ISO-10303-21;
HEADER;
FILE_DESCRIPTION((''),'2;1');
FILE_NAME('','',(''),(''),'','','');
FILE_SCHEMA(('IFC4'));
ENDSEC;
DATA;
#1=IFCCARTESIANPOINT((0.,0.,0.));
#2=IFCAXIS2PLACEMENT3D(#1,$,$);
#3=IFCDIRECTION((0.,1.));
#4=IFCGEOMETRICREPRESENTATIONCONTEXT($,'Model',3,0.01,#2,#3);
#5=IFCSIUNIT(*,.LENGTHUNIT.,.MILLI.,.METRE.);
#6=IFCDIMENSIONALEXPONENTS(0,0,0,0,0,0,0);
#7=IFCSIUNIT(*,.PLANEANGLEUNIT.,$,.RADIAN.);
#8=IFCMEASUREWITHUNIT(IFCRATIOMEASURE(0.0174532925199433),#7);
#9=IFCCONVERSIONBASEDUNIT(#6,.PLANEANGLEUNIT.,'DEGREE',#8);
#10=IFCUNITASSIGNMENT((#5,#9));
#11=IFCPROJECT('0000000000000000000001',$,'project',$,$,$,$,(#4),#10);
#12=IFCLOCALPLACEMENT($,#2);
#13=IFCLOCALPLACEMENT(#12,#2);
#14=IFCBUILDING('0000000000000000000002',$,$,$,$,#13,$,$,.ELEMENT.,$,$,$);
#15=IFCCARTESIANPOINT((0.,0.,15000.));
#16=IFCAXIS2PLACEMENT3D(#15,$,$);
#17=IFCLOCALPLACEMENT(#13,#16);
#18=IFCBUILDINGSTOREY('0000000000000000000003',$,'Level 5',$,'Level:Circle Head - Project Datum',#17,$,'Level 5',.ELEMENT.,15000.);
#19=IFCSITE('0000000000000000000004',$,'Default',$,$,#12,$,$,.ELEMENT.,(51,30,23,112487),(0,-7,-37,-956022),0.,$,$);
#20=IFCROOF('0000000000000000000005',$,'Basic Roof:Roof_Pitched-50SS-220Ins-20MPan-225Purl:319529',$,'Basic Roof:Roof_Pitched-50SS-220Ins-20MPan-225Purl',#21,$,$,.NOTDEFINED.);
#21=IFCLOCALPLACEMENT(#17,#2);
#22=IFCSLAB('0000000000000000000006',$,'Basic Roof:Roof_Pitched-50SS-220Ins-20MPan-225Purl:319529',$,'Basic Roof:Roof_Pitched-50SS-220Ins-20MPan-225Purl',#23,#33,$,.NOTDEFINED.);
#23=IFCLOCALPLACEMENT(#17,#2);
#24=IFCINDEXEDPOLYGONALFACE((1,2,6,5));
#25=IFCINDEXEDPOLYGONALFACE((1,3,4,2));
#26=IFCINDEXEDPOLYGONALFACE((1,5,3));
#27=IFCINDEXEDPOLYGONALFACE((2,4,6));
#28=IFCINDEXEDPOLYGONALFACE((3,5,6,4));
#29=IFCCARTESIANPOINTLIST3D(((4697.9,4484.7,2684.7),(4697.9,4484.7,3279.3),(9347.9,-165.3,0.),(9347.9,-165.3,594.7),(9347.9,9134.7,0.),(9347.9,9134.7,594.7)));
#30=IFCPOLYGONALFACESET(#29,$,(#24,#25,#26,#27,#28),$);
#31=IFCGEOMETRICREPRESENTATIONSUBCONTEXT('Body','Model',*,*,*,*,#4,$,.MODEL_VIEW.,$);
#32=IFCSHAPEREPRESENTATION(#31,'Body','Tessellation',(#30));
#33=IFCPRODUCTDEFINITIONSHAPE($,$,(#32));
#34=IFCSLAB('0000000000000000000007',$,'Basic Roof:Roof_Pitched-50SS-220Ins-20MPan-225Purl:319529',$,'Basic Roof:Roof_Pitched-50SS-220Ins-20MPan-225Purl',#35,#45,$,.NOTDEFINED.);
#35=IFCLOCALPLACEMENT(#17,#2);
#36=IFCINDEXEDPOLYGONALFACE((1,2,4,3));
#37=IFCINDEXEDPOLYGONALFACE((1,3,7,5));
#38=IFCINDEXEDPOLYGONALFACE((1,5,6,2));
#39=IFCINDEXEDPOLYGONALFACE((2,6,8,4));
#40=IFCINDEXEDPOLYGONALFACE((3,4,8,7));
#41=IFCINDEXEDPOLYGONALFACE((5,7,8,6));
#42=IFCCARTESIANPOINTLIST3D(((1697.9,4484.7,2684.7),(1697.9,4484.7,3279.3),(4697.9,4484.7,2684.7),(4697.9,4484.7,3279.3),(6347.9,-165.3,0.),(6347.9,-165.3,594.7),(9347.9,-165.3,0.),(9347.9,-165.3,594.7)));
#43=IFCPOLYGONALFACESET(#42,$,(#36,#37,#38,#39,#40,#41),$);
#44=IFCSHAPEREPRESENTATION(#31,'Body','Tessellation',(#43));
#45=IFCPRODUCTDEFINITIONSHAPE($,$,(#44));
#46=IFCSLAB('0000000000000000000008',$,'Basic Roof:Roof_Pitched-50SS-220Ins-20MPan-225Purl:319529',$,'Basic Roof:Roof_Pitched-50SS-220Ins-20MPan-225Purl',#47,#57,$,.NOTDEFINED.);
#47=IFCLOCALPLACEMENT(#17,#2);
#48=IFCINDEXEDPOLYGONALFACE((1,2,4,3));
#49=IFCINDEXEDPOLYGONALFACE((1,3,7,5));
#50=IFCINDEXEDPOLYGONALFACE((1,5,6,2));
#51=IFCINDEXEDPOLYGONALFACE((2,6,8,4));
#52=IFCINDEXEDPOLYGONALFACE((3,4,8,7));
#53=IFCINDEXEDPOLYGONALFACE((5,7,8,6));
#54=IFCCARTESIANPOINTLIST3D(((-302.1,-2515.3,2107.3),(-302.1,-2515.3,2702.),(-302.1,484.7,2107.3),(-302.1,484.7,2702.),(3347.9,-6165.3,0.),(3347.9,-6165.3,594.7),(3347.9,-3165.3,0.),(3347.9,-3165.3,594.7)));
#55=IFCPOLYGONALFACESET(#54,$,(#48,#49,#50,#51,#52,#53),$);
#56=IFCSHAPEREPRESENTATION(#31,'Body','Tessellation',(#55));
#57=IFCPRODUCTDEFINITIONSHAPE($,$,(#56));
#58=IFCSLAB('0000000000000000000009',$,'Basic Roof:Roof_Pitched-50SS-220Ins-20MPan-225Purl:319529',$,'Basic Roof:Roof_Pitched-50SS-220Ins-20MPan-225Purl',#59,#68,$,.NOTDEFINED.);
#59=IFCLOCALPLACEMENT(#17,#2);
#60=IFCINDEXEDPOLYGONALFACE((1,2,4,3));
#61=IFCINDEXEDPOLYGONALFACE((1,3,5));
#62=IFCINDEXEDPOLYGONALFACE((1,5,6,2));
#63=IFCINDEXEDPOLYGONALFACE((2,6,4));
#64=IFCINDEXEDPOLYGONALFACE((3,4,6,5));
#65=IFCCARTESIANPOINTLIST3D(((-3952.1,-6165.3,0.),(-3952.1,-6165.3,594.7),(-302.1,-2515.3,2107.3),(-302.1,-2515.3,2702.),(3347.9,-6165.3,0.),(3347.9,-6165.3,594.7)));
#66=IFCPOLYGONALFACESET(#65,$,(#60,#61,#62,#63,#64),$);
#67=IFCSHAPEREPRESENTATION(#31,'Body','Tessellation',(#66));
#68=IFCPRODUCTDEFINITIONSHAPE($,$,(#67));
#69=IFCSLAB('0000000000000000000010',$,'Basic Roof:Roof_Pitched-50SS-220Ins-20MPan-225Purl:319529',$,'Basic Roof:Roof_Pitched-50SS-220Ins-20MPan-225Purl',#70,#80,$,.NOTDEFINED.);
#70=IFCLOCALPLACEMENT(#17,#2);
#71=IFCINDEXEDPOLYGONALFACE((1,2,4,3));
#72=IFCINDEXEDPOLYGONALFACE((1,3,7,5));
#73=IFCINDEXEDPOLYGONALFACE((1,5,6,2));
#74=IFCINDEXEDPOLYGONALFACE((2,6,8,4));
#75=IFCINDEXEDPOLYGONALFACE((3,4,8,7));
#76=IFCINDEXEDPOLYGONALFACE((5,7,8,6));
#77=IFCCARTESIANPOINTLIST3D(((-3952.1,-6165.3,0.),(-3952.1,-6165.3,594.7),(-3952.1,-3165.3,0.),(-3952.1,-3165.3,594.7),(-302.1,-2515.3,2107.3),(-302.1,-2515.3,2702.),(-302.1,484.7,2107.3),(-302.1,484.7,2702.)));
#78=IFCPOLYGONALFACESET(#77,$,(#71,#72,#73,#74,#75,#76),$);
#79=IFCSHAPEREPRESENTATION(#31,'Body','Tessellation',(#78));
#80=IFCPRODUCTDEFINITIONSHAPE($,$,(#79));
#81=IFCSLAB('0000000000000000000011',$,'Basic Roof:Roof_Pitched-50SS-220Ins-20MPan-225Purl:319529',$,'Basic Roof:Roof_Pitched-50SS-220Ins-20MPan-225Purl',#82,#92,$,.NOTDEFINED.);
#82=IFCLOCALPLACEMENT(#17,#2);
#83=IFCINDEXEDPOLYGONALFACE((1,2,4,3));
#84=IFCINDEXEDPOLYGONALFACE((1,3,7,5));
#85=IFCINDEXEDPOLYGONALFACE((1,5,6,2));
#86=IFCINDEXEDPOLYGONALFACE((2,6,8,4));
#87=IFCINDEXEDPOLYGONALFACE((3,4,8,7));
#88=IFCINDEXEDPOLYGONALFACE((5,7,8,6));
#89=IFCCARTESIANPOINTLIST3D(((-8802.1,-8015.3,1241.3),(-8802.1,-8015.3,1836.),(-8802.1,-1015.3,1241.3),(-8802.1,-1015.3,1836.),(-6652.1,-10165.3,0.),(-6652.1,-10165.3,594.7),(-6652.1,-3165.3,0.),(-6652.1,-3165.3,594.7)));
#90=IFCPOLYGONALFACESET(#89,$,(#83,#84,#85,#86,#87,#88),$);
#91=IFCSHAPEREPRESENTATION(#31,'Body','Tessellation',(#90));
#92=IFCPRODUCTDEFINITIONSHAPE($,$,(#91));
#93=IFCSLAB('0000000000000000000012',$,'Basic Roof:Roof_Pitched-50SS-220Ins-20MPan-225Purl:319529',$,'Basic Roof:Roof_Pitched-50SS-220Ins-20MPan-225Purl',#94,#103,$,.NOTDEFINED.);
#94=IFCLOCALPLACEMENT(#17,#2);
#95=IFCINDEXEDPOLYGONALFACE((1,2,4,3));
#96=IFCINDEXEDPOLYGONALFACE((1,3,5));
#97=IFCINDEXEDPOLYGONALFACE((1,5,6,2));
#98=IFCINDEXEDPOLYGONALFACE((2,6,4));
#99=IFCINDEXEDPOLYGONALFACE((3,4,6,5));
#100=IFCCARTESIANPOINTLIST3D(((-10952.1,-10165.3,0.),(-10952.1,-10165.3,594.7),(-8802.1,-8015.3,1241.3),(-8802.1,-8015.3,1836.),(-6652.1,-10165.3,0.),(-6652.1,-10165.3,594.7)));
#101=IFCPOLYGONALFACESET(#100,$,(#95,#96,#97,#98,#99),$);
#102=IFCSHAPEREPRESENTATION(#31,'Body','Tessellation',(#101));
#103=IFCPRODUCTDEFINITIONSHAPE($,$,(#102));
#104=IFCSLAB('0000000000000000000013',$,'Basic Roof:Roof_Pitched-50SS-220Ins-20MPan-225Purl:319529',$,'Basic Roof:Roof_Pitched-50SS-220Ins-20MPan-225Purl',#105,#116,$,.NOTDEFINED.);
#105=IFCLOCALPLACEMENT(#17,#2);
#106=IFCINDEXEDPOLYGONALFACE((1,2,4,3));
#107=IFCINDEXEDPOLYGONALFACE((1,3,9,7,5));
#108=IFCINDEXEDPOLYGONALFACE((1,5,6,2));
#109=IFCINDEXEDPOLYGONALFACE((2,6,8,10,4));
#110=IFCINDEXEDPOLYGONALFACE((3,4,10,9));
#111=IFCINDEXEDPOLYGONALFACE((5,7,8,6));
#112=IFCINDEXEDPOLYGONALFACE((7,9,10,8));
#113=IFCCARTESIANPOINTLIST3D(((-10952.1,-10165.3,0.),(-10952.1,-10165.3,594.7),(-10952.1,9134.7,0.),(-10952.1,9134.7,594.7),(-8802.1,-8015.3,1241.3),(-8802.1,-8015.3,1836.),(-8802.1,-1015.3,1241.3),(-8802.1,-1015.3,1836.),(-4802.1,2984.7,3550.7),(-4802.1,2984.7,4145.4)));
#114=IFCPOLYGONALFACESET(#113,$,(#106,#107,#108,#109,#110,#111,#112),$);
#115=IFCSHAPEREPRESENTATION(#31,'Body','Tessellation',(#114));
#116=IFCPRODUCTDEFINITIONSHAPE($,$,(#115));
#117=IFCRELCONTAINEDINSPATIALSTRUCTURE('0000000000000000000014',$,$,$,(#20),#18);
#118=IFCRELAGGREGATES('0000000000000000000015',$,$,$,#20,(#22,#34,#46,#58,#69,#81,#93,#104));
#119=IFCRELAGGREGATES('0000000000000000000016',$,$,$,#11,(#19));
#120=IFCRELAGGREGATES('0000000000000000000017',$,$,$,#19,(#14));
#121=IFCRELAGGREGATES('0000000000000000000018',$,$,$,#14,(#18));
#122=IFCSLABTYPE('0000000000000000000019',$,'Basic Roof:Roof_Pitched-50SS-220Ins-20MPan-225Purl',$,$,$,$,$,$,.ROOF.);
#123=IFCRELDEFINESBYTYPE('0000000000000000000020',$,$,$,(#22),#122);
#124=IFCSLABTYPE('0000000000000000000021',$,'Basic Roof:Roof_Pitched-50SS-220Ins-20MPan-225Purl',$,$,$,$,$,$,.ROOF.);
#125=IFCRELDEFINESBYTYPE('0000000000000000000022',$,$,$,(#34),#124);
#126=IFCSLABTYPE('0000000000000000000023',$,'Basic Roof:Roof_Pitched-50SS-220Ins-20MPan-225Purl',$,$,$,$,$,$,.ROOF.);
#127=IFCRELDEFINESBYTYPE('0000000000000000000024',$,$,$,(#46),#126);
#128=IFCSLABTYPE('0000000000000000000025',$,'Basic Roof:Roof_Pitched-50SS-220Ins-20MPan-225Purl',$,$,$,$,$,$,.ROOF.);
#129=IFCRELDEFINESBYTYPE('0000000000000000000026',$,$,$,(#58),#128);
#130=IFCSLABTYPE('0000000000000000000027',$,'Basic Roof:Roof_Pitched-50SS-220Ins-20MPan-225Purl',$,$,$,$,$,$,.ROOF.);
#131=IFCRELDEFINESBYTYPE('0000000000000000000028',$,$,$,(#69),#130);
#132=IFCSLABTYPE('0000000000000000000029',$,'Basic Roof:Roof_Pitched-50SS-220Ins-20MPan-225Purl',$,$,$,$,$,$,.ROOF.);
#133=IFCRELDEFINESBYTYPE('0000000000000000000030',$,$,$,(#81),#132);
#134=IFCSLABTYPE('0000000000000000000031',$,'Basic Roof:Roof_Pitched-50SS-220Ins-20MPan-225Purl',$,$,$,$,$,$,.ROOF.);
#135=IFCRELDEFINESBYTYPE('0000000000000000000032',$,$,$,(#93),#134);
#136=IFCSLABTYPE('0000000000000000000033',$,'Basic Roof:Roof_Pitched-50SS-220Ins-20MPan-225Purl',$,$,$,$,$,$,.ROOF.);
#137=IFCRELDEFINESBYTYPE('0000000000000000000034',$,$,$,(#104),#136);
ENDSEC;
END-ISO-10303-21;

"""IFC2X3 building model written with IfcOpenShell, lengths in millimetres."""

from ifc_helpers import new_model, entity, si_unit, converted_unit, direction, frame, origin, place, context, subcontext, project, spatial, polyline, outline, extrude, type_object, element, aggregate, save


model = new_model("IFC2X3")

# Units and contexts
model_context = context("Model", 3, precision=0.01, world=origin(), true_north=direction((0.0, 1.0)))
body_context = subcontext(model_context, "Body", "Model", "MODEL_VIEW")
ifc_project = project(units=[si_unit("LENGTHUNIT", "METRE", prefix="MILLI"), converted_unit("PLANEANGLEUNIT", "DEGREE", entity("IfcRatioMeasure", 0.0174532925199433), si_unit("PLANEANGLEUNIT", "RADIAN"), dimensions=[0, 0, 0, 0, 0, 0, 0])], contexts=[model_context])

# Site, building, storey
site_placement = place(None, origin())
site = spatial("IfcSite", under=ifc_project, at=site_placement, Name="Default", CompositionType="ELEMENT", RefLatitude=(51, 30, 23, 112487), RefLongitude=(0, -7, -37, -956022), RefElevation=0.0)
building_placement = place(site_placement, origin())
building = spatial("IfcBuilding", under=site, at=building_placement, CompositionType="ELEMENT")
storey_placement = place(building_placement, frame((0.0, 0.0, 15000.0)))
storey = spatial("IfcBuildingStorey", under=building, at=storey_placement, Name="Level 5", ObjectType="Level:Circle Head - Project Datum", LongName="Level 5", CompositionType="ELEMENT", Elevation=15000.0)

# Roof, slabs
roof_placement = place(storey_placement, frame((-10952.1, -10165.3, 0.0)))
roof = element("IfcRoof", 1, at=roof_placement, inside=storey, Name="Basic Roof:Roof_Pitched-50SS-220Ins-20MPan-225Purl:319529", ObjectType="Basic Roof:Roof_Pitched-50SS-220Ins-20MPan-225Purl", ShapeType="NOTDEFINED")
slab_type_1 = type_object("IfcSlabType", Name="Basic Roof:Roof_Pitched-50SS-220Ins-20MPan-225Purl", PredefinedType="ROOF")
slab_1_placement = place(roof_placement, origin())
slab_1 = element("IfcSlab", 2, at=slab_1_placement, type_object=slab_type_1, Name="Basic Roof:Roof_Pitched-50SS-220Ins-20MPan-225Purl:319529", ObjectType="Basic Roof:Roof_Pitched-50SS-220Ins-20MPan-225Purl", PredefinedType="NOTDEFINED", context=body_context, shape_type="SweptSolid", body=[
    extrude(outline(polyline([(-2684.7, 0.0), (2684.7, -4650.0), (2684.7, 4650.0), (-2684.7, 0.0)])), frame((17975.0, 14650.0, 1342.3), z_axis=(0.5, 0.0, 0.866025), x_axis=(0.866025, 0.0, -0.5)), (-0.5, 0.0, 0.866025), 594.7),
])
slab_type_2 = type_object("IfcSlabType", Name="Basic Roof:Roof_Pitched-50SS-220Ins-20MPan-225Purl", PredefinedType="ROOF")
slab_2_placement = place(roof_placement, origin())
slab_2 = element("IfcSlab", 3, at=slab_2_placement, type_object=slab_type_2, Name="Basic Roof:Roof_Pitched-50SS-220Ins-20MPan-225Purl:319529", ObjectType="Basic Roof:Roof_Pitched-50SS-220Ins-20MPan-225Purl", PredefinedType="NOTDEFINED", context=body_context, shape_type="SweptSolid", body=[
    extrude(outline(polyline([(3825.0, -2684.7), (-825.0, 2684.7), (-3825.0, 2684.7), (825.0, -2684.7), (3825.0, -2684.7)])), frame((16475.0, 12325.0, 1342.3), z_axis=(0.0, -0.5, 0.866025), x_axis=(1.0, 0.0, 0.0)), (0.0, 0.5, 0.866025), 594.7),
])
slab_type_3 = type_object("IfcSlabType", Name="Basic Roof:Roof_Pitched-50SS-220Ins-20MPan-225Purl", PredefinedType="ROOF")
slab_3_placement = place(roof_placement, origin())
slab_3 = element("IfcSlab", 4, at=slab_3_placement, type_object=slab_type_3, Name="Basic Roof:Roof_Pitched-50SS-220Ins-20MPan-225Purl:319529", ObjectType="Basic Roof:Roof_Pitched-50SS-220Ins-20MPan-225Purl", PredefinedType="NOTDEFINED", context=body_context, shape_type="SweptSolid", body=[
    extrude(outline(polyline([(2107.3, -3325.0), (2107.3, -325.0), (-2107.3, 3325.0), (-2107.3, 325.0), (2107.3, -3325.0)])), frame((12475.0, 7325.0, 1053.7), z_axis=(0.5, 0.0, 0.866025), x_axis=(0.866025, 0.0, -0.5)), (-0.5, 0.0, 0.866025), 594.7),
])
slab_type_4 = type_object("IfcSlabType", Name="Basic Roof:Roof_Pitched-50SS-220Ins-20MPan-225Purl", PredefinedType="ROOF")
slab_4_placement = place(roof_placement, origin())
slab_4 = element("IfcSlab", 5, at=slab_4_placement, type_object=slab_type_4, Name="Basic Roof:Roof_Pitched-50SS-220Ins-20MPan-225Purl:319529", ObjectType="Basic Roof:Roof_Pitched-50SS-220Ins-20MPan-225Purl", PredefinedType="NOTDEFINED", context=body_context, shape_type="SweptSolid", body=[
    extrude(outline(polyline([(-3650.0, -2107.3), (3650.0, -2107.3), (0.0, 2107.3), (-3650.0, -2107.3)])), frame((10650.0, 5825.0, 1053.7), z_axis=(0.0, -0.5, 0.866025), x_axis=(1.0, 0.0, 0.0)), (0.0, 0.5, 0.866025), 594.7),
])
slab_type_5 = type_object("IfcSlabType", Name="Basic Roof:Roof_Pitched-50SS-220Ins-20MPan-225Purl", PredefinedType="ROOF")
slab_5_placement = place(roof_placement, origin())
slab_5 = element("IfcSlab", 6, at=slab_5_placement, type_object=slab_type_5, Name="Basic Roof:Roof_Pitched-50SS-220Ins-20MPan-225Purl:319529", ObjectType="Basic Roof:Roof_Pitched-50SS-220Ins-20MPan-225Purl", PredefinedType="NOTDEFINED", context=body_context, shape_type="SweptSolid", body=[
    extrude(outline(polyline([(-2107.3, -325.0), (-2107.3, -3325.0), (2107.3, 325.0), (2107.3, 3325.0), (-2107.3, -325.0)])), frame((8825.0, 7325.0, 1053.7), z_axis=(-0.5, 0.0, 0.866025), x_axis=(0.866025, 0.0, 0.5)), (0.5, 0.0, 0.866025), 594.7),
])
slab_type_6 = type_object("IfcSlabType", Name="Basic Roof:Roof_Pitched-50SS-220Ins-20MPan-225Purl", PredefinedType="ROOF")
slab_6_placement = place(roof_placement, origin())
slab_6 = element("IfcSlab", 7, at=slab_6_placement, type_object=slab_type_6, Name="Basic Roof:Roof_Pitched-50SS-220Ins-20MPan-225Purl:319529", ObjectType="Basic Roof:Roof_Pitched-50SS-220Ins-20MPan-225Purl", PredefinedType="NOTDEFINED", context=body_context, shape_type="SweptSolid", body=[
    extrude(outline(polyline([(1241.3, -4575.0), (1241.3, 2425.0), (-1241.3, 4575.0), (-1241.3, -2425.0), (1241.3, -4575.0)])), frame((3225.0, 4575.0, 620.7), z_axis=(0.5, 0.0, 0.866025), x_axis=(0.866025, 0.0, -0.5)), (-0.5, 0.0, 0.866025), 594.7),
])
slab_type_7 = type_object("IfcSlabType", Name="Basic Roof:Roof_Pitched-50SS-220Ins-20MPan-225Purl", PredefinedType="ROOF")
slab_7_placement = place(roof_placement, origin())
slab_7 = element("IfcSlab", 8, at=slab_7_placement, type_object=slab_type_7, Name="Basic Roof:Roof_Pitched-50SS-220Ins-20MPan-225Purl:319529", ObjectType="Basic Roof:Roof_Pitched-50SS-220Ins-20MPan-225Purl", PredefinedType="NOTDEFINED", context=body_context, shape_type="SweptSolid", body=[
    extrude(outline(polyline([(-2150.0, -1241.3), (2150.0, -1241.3), (0.0, 1241.3), (-2150.0, -1241.3)])), frame((2150.0, 1075.0, 620.7), z_axis=(0.0, -0.5, 0.866025), x_axis=(1.0, 0.0, 0.0)), (0.0, 0.5, 0.866025), 594.7),
])
slab_type_8 = type_object("IfcSlabType", Name="Basic Roof:Roof_Pitched-50SS-220Ins-20MPan-225Purl", PredefinedType="ROOF")
slab_8_placement = place(roof_placement, origin())
slab_8 = element("IfcSlab", 9, at=slab_8_placement, type_object=slab_type_8, Name="Basic Roof:Roof_Pitched-50SS-220Ins-20MPan-225Purl:319529", ObjectType="Basic Roof:Roof_Pitched-50SS-220Ins-20MPan-225Purl", PredefinedType="NOTDEFINED", context=body_context, shape_type="SweptSolid", body=[
    extrude(outline(polyline([(-3550.7, 9650.0), (-3550.7, -9650.0), (-1068.1, -7500.0), (-1068.1, -500.0), (3550.7, 3500.0), (-3550.7, 9650.0)])), frame((3075.0, 9650.0, 1775.4), z_axis=(-0.5, 0.0, 0.866025), x_axis=(0.866025, 0.0, 0.5)), (0.5, 0.0, 0.866025), 594.7),
])
aggregate(roof, [slab_1, slab_2, slab_3, slab_4, slab_5, slab_6, slab_7, slab_8])

save(model, "model.ifc")
